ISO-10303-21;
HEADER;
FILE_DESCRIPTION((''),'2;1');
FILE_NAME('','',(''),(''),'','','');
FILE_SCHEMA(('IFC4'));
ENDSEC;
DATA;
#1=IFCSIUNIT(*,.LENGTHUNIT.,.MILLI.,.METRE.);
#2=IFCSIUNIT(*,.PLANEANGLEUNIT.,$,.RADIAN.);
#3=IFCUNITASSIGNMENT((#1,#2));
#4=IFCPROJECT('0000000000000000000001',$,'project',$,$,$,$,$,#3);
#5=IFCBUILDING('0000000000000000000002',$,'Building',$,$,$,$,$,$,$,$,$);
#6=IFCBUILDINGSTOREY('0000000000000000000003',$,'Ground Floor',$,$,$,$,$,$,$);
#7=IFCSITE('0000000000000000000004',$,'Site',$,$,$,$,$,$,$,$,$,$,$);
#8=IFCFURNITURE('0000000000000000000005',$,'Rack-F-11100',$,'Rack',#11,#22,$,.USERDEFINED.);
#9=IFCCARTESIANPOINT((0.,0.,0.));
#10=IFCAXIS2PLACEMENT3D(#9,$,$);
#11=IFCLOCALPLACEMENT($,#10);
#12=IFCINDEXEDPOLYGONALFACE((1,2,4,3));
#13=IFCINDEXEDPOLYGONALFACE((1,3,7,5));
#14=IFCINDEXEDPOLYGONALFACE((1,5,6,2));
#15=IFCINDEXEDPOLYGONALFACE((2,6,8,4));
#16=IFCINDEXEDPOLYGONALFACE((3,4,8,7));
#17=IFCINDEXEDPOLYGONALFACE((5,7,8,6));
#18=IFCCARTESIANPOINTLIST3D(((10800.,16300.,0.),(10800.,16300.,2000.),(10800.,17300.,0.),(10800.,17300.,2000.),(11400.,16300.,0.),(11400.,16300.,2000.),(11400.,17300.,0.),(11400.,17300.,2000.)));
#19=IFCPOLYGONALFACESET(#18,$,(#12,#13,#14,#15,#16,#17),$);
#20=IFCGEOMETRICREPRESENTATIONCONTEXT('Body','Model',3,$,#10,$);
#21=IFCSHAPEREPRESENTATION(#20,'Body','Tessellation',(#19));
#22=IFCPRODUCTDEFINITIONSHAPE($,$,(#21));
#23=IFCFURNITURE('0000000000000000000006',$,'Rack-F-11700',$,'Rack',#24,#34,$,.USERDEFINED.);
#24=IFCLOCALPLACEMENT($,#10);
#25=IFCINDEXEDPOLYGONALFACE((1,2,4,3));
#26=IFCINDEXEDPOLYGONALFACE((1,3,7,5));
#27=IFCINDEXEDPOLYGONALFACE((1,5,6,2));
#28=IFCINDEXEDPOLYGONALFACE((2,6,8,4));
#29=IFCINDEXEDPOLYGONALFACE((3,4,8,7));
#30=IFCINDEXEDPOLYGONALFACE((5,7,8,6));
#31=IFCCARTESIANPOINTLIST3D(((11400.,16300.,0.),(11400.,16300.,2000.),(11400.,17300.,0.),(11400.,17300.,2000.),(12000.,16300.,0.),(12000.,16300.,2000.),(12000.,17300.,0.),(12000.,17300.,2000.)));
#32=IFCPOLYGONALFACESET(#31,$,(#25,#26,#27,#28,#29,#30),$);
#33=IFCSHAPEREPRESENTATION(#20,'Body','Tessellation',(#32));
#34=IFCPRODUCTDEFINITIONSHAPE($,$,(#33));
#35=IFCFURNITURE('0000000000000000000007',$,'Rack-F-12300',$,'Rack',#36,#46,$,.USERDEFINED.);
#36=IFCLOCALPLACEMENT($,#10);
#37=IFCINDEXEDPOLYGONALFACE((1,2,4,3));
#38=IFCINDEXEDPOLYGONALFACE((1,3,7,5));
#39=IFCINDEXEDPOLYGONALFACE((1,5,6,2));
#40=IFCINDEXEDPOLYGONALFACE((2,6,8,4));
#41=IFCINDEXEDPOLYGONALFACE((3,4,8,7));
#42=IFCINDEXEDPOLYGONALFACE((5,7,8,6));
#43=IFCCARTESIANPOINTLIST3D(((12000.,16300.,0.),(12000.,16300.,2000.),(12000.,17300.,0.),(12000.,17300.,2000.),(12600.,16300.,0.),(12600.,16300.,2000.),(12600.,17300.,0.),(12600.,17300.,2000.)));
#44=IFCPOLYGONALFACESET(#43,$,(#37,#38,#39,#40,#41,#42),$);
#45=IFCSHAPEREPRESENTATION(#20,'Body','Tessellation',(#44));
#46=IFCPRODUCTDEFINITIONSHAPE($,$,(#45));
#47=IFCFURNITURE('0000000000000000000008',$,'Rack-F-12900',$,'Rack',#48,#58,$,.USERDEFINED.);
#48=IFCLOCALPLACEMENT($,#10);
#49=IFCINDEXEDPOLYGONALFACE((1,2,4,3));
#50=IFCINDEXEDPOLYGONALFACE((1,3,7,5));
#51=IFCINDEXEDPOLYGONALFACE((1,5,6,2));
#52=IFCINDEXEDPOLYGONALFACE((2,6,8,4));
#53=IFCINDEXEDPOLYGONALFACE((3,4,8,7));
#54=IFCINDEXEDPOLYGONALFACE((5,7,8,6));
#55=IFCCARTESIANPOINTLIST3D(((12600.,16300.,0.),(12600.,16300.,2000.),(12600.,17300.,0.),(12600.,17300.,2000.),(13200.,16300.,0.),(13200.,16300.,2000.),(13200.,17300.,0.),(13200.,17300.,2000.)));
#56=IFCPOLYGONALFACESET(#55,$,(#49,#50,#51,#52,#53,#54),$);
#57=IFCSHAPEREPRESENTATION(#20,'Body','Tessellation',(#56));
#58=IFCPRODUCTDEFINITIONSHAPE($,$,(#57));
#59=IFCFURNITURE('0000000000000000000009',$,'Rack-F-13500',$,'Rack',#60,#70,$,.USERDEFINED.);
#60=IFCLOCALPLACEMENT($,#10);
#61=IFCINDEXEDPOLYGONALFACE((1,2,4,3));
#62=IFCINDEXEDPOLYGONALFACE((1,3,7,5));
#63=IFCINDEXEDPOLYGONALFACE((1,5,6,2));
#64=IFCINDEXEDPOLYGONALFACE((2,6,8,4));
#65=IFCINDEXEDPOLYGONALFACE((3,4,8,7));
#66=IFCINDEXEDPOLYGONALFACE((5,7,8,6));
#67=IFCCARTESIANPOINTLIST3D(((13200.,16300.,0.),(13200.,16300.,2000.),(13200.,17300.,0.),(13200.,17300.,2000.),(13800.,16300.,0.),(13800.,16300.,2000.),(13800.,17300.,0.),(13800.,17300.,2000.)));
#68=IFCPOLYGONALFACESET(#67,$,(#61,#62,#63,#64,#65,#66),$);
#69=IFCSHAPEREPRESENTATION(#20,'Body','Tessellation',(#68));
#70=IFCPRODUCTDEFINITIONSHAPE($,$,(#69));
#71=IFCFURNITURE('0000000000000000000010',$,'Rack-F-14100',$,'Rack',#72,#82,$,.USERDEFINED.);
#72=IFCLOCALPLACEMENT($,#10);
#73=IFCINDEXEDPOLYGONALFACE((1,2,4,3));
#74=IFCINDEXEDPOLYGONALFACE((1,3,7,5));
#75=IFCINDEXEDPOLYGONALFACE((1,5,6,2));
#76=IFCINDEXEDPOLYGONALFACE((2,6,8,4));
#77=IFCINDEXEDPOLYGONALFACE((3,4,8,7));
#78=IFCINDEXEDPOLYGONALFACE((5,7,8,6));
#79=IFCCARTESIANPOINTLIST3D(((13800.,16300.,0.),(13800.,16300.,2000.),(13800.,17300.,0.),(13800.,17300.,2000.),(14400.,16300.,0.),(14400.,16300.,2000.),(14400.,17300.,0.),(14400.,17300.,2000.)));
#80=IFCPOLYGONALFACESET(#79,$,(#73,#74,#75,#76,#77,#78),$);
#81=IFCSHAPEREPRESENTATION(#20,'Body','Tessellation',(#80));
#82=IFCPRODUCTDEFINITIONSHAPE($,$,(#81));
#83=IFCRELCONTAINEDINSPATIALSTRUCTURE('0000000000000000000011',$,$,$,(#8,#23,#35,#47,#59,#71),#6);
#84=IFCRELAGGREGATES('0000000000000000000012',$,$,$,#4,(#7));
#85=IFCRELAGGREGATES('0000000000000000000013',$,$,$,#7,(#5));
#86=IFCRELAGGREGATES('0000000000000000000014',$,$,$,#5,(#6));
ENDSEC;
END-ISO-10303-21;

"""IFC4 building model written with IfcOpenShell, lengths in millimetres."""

from ifc_helpers import new_model, si_unit, frame, origin, place, context, project, spatial, rectangle, extrude, element, save


model = new_model("IFC4")

# Units and contexts
model_context = context("Model", 3, world=origin(), identifier="Body")
ifc_project = project(units=[si_unit("LENGTHUNIT", "METRE", prefix="MILLI"), si_unit("PLANEANGLEUNIT", "RADIAN")])

# Site, building, storey
site = spatial("IfcSite", under=ifc_project, Name="Site")
building = spatial("IfcBuilding", under=site, Name="Building")
storey = spatial("IfcBuildingStorey", under=building, Name="Ground Floor")

# Furniture
for number, where, z_axis, x_axis, name in (
    (1, (11100.0, 16800.0, 0.0), (0.0, 0.0, 1.0), (1.0, 0.0, 0.0), "Rack-F-11100"),
    (2, (11700.0, 16800.0, 0.0), (0.0, 0.0, 1.0), (1.0, 0.0, 0.0), "Rack-F-11700"),
    (3, (12300.0, 16800.0, 0.0), (0.0, 0.0, 1.0), (1.0, 0.0, 0.0), "Rack-F-12300"),
    (4, (12900.0, 16800.0, 0.0), (0.0, 0.0, 1.0), (1.0, 0.0, 0.0), "Rack-F-12900"),
    (5, (13500.0, 16800.0, 0.0), (0.0, 0.0, 1.0), (1.0, 0.0, 0.0), "Rack-F-13500"),
    (6, (14100.0, 16800.0, 0.0), (0.0, 0.0, 1.0), (1.0, 0.0, 0.0), "Rack-F-14100"),
):
    element("IfcFurniture", number, at=place(None, frame(where, z_axis=z_axis, x_axis=x_axis)), inside=storey, Name=name, ObjectType="Rack", PredefinedType="USERDEFINED", context=model_context, shape_type="SweptSolid", body=[
        extrude(rectangle(XDim=600.0, YDim=1000.0), origin(), (0.0, 0.0, 1.0), 2000.0),
    ])

save(model, "model.ifc")
